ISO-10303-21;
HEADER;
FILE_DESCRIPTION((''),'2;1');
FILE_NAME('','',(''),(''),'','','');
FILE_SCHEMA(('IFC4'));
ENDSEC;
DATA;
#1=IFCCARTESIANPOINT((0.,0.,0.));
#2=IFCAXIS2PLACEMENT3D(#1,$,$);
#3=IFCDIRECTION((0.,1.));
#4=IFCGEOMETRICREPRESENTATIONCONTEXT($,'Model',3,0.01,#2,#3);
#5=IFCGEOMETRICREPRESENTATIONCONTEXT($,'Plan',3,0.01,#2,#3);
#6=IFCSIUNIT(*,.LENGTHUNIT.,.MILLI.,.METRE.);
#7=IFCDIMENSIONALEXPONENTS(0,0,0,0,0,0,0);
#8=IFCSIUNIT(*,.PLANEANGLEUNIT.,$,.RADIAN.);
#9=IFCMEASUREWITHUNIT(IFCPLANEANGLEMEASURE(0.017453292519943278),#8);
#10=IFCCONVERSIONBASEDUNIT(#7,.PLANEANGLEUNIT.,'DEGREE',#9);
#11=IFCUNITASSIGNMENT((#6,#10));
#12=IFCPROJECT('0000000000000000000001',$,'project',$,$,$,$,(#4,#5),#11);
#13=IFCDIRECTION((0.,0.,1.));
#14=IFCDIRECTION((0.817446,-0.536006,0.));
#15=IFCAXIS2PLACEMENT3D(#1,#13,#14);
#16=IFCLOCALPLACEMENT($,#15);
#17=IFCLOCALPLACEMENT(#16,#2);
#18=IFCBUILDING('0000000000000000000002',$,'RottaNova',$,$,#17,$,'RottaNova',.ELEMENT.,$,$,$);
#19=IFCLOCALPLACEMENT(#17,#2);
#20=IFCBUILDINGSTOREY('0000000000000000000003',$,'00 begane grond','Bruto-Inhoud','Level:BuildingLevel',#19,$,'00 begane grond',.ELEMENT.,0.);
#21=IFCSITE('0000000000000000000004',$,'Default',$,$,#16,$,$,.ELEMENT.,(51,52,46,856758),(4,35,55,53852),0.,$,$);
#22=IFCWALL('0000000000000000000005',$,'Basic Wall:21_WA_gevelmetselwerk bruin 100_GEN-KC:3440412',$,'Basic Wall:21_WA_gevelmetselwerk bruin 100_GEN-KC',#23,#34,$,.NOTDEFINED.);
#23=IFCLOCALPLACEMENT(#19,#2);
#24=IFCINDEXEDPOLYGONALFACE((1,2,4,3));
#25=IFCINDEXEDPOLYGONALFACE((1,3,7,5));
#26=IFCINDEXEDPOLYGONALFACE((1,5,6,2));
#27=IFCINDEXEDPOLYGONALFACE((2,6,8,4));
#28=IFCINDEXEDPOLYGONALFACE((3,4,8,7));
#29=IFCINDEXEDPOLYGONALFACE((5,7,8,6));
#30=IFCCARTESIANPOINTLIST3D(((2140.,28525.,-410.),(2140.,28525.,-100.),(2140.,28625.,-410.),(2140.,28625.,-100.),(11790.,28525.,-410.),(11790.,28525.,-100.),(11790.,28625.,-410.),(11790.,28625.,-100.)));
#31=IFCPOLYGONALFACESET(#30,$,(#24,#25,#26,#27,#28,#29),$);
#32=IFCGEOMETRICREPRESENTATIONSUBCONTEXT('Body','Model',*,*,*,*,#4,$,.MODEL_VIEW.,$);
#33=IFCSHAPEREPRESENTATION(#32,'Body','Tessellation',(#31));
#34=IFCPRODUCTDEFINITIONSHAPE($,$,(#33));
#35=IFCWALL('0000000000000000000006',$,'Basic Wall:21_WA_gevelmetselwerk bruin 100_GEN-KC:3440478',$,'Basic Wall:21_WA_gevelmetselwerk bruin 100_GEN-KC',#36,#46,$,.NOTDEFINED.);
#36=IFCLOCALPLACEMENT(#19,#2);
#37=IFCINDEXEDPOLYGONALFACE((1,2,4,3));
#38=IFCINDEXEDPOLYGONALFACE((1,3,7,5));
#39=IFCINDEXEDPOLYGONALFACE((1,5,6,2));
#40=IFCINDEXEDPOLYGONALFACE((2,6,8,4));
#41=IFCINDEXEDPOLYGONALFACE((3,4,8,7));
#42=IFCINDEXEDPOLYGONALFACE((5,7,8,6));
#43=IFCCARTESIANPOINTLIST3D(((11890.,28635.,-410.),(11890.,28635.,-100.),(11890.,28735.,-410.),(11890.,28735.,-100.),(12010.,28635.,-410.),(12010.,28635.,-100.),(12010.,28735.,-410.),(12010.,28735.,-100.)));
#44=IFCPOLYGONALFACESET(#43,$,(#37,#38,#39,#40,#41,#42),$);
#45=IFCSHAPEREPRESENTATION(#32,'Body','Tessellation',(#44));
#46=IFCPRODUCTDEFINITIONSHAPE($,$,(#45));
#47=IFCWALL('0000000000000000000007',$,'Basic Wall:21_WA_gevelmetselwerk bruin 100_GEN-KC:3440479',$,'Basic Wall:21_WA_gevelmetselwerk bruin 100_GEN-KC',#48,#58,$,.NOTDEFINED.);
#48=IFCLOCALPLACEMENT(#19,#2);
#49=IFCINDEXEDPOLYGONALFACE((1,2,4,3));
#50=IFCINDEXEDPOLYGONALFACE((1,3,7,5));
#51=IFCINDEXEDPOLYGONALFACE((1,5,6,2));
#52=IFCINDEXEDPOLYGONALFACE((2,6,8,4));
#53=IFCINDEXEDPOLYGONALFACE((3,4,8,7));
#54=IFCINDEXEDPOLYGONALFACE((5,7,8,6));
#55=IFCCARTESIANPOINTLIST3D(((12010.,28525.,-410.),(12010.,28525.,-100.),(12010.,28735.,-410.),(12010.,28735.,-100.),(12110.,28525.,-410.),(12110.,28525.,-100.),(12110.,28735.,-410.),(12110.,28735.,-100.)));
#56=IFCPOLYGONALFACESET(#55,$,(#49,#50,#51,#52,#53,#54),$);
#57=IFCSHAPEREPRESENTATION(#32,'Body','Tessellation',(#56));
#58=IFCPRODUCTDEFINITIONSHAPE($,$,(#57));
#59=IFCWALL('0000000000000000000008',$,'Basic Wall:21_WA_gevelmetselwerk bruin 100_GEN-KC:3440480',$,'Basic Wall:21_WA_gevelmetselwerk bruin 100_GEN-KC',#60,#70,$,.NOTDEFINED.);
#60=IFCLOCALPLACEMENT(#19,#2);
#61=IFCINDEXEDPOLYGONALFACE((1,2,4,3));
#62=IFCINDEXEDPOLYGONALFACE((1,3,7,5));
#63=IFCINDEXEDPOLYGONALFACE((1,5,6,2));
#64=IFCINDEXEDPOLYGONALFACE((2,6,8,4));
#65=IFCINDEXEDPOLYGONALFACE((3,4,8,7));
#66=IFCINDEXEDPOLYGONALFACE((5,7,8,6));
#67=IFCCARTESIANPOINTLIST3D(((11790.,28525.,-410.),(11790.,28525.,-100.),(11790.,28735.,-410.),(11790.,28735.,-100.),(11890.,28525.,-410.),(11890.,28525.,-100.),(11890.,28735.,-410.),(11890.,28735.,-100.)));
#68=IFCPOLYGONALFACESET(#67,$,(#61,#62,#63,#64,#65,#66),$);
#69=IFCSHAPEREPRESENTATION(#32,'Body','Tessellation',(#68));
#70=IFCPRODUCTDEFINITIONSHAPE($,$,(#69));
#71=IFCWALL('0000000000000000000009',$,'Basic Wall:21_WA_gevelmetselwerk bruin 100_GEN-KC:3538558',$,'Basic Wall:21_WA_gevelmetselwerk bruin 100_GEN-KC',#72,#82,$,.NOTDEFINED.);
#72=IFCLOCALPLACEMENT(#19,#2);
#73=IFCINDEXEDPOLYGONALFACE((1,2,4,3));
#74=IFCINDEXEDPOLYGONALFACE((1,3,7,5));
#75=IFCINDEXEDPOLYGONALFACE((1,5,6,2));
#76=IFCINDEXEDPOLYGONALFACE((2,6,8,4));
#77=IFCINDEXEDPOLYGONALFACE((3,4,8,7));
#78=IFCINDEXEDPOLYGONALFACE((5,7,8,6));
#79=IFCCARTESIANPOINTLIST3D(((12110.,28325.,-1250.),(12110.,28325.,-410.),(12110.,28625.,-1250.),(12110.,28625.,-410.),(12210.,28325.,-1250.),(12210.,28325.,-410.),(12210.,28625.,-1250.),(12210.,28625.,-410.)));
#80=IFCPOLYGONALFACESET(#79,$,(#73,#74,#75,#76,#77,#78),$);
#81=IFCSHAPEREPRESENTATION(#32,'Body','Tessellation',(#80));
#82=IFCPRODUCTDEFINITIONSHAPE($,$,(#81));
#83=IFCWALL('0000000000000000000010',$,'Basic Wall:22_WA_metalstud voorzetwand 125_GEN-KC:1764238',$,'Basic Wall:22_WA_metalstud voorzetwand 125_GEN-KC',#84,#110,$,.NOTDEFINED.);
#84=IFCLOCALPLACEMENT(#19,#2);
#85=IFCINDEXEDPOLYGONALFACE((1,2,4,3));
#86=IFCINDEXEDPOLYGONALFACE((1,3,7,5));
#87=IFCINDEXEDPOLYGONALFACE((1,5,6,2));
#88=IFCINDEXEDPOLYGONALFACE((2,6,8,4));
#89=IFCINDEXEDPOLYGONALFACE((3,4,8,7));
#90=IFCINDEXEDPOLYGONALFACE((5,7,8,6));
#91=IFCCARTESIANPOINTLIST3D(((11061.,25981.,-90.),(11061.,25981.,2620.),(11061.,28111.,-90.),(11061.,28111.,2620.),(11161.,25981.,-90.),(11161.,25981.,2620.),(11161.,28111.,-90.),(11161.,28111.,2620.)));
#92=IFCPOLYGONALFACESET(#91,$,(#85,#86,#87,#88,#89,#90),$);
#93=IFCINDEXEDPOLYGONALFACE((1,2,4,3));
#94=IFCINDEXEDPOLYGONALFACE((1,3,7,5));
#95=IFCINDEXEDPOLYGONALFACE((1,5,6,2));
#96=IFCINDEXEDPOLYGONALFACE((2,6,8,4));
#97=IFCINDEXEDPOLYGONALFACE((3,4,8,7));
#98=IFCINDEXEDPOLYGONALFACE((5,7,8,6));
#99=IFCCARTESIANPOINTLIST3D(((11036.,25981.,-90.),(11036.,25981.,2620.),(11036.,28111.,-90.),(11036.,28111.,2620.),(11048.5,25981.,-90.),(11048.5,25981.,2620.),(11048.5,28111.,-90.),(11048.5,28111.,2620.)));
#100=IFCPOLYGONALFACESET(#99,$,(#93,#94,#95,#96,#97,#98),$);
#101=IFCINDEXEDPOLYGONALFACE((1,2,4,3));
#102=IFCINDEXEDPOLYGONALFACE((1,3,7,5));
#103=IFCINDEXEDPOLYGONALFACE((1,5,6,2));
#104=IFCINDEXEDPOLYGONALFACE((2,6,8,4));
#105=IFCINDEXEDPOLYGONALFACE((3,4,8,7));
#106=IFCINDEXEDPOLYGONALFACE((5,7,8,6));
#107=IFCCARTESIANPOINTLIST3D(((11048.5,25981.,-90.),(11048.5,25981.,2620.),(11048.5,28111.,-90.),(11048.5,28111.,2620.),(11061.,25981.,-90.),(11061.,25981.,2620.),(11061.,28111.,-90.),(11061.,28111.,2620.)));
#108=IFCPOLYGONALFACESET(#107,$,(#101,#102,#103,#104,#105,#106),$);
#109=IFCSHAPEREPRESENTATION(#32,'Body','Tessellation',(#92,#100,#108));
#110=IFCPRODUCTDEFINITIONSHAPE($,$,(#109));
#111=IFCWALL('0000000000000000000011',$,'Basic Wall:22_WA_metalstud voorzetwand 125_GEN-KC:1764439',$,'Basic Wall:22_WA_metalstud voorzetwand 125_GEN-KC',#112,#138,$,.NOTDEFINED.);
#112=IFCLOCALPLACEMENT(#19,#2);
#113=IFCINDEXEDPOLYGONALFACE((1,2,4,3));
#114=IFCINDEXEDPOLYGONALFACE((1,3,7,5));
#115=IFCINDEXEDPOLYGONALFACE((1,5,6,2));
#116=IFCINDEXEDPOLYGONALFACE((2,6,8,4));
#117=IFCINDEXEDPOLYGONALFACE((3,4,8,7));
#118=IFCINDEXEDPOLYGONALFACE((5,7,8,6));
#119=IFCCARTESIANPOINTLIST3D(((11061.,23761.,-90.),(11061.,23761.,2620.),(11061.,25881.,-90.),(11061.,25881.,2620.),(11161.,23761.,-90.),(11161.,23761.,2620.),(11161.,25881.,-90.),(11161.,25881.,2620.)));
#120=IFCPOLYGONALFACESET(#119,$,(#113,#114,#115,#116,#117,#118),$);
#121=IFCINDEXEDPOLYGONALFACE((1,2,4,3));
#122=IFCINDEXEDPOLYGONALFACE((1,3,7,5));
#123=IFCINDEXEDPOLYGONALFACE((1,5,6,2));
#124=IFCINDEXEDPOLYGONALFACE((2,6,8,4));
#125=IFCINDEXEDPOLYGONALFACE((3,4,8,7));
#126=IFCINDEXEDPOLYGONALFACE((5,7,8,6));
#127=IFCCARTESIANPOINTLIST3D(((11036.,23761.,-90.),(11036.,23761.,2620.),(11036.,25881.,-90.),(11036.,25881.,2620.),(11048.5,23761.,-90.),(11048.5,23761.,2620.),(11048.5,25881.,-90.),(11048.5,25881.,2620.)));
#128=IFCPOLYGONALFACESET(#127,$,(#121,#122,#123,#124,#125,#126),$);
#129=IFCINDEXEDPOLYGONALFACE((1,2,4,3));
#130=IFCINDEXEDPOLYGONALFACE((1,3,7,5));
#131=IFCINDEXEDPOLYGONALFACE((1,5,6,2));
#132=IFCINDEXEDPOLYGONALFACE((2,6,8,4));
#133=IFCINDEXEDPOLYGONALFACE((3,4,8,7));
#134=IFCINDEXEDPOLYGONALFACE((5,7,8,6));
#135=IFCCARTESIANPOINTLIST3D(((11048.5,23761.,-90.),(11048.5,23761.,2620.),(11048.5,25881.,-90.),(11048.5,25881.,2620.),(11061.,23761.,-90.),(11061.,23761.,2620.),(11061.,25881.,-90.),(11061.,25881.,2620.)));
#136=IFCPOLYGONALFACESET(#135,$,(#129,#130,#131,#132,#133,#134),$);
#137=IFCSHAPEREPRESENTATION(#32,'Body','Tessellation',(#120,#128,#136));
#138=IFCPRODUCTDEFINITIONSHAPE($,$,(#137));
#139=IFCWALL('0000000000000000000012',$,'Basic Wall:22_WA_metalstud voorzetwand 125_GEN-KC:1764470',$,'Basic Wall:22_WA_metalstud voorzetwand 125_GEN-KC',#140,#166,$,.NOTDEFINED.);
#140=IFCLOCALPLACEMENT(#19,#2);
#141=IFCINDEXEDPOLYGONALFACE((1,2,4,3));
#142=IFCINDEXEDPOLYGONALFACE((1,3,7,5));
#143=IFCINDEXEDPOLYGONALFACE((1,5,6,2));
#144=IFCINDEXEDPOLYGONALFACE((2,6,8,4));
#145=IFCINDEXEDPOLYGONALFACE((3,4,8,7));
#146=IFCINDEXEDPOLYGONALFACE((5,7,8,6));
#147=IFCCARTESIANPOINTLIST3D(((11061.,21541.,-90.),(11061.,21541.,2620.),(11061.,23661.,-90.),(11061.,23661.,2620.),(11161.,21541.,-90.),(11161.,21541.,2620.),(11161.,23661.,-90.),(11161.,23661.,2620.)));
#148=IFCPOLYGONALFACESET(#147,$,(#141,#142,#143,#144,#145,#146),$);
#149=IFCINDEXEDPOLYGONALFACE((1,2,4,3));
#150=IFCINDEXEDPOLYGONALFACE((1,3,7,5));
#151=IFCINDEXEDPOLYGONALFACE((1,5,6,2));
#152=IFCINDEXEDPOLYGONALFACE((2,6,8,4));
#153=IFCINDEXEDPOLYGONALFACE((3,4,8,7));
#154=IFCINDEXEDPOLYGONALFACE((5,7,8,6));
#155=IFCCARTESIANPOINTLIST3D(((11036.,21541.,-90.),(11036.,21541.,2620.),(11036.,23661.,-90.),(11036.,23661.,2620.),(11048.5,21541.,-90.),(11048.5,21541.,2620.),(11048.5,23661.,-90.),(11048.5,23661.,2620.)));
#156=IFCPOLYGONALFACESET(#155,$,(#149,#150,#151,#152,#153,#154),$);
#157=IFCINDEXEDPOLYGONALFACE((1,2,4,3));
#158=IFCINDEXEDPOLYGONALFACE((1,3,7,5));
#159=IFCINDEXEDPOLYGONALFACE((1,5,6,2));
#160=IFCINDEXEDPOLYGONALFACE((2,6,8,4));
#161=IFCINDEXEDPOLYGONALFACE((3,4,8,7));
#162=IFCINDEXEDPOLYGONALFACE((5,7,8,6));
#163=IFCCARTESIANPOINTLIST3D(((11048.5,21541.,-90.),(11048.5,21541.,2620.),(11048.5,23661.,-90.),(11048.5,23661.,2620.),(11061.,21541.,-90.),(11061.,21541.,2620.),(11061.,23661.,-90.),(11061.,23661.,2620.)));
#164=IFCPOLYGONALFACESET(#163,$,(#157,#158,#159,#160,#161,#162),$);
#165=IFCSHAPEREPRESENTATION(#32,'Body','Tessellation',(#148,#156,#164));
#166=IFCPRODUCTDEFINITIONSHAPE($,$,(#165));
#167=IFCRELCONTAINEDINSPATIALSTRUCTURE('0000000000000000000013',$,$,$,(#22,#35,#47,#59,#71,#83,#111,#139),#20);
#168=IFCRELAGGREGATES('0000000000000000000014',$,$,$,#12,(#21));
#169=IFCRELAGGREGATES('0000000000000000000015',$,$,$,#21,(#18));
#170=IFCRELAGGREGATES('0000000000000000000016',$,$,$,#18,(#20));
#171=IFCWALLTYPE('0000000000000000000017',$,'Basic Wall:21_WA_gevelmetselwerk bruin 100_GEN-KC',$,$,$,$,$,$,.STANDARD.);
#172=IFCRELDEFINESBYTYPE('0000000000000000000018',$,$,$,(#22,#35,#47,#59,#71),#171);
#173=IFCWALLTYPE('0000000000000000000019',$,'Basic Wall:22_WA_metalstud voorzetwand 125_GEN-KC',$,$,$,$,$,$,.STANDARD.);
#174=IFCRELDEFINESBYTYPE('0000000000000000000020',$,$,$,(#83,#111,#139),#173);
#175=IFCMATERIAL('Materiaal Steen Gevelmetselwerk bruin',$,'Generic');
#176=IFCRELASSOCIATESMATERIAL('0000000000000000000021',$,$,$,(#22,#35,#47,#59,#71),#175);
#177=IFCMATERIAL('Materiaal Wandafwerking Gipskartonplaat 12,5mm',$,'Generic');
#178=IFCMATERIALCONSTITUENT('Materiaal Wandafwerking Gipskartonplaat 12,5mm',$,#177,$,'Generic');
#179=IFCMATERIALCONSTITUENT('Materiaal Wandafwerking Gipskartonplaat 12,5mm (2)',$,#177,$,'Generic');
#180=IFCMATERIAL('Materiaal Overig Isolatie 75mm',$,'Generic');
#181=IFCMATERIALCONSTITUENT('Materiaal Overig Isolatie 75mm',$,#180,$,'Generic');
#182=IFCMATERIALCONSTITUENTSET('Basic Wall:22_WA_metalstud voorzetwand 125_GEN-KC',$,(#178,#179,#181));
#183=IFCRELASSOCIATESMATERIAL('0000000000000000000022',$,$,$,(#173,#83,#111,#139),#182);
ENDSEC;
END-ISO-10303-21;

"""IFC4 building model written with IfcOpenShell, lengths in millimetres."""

from ifc_helpers import new_model, entity, si_unit, converted_unit, direction, frame, origin, place, context, subcontext, project, spatial, indexed_curve, outline, extrude, material, constituent, constituent_set, type_object, element, save


model = new_model("IFC4")

# Units and contexts
model_context = context("Model", 3, precision=0.01, world=origin(), true_north=direction((0.0, 1.0)))
plan_context = context("Plan", 3, precision=0.01, world=origin(), true_north=direction((0.0, 1.0)))
body_context = subcontext(model_context, "Body", "Model", "MODEL_VIEW")
ifc_project = project(units=[si_unit("LENGTHUNIT", "METRE", prefix="MILLI"), converted_unit("PLANEANGLEUNIT", "DEGREE", entity("IfcPlaneAngleMeasure", 0.017453292519943278), si_unit("PLANEANGLEUNIT", "RADIAN"), dimensions=[0, 0, 0, 0, 0, 0, 0])], contexts=[model_context, plan_context])

# Site, building, storey
site_placement = place(None, frame((0.0, 0.0, 0.0), z_axis=(0.0, 0.0, 1.0), x_axis=(0.817446, -0.536006, 0.0)))
site = spatial("IfcSite", under=ifc_project, at=site_placement, Name="Default", CompositionType="ELEMENT", RefLatitude=(51, 52, 46, 856758), RefLongitude=(4, 35, 55, 53852), RefElevation=0.0)
building_placement = place(site_placement, origin())
building = spatial("IfcBuilding", under=site, at=building_placement, Name="RottaNova", LongName="RottaNova", CompositionType="ELEMENT")
storey_placement = place(building_placement, origin())
storey = spatial("IfcBuildingStorey", under=building, at=storey_placement, Name="00 begane grond", Description="Bruto-Inhoud", ObjectType="Level:BuildingLevel", LongName="00 begane grond", CompositionType="ELEMENT", Elevation=0.0)

# Walls
ifc_material_1 = material(Name="Materiaal Steen Gevelmetselwerk bruin", Category="Generic")
wall_type_1 = type_object("IfcWallType", Name="Basic Wall:21_WA_gevelmetselwerk bruin 100_GEN-KC", PredefinedType="STANDARD")
wall_1_placement = place(storey_placement, frame((11790.0, 28575.0, -410.0), z_axis=(0.0, 0.0, 1.0), x_axis=(-1.0, 0.0, 0.0)))
element("IfcWall", 1, at=wall_1_placement, inside=storey, type_object=wall_type_1, material=ifc_material_1, Name="Basic Wall:21_WA_gevelmetselwerk bruin 100_GEN-KC:3440412", ObjectType="Basic Wall:21_WA_gevelmetselwerk bruin 100_GEN-KC", PredefinedType="NOTDEFINED", context=body_context, shape_type="SweptSolid", body=[
    extrude(outline(indexed_curve([(9650.0, 50.0), (0.0, 50.0), (0.0, -50.0), (9650.0, -50.0), (9650.0, 50.0)], self_intersect=False)), origin(), (0.0, 0.0, 1.0), 310.0),
])
wall_2_placement = place(storey_placement, frame((12010.0, 28685.0, -410.0), z_axis=(0.0, 0.0, 1.0), x_axis=(-1.0, 0.0, 0.0)))
element("IfcWall", 2, at=wall_2_placement, inside=storey, type_object=wall_type_1, material=ifc_material_1, Name="Basic Wall:21_WA_gevelmetselwerk bruin 100_GEN-KC:3440478", ObjectType="Basic Wall:21_WA_gevelmetselwerk bruin 100_GEN-KC", PredefinedType="NOTDEFINED", context=body_context, shape_type="SweptSolid", body=[
    extrude(outline(indexed_curve([(120.0, 50.0), (0.0, 50.0), (0.0, -50.0), (120.0, -50.0), (120.0, 50.0)], self_intersect=False)), origin(), (0.0, 0.0, 1.0), 310.0),
])
wall_3_placement = place(storey_placement, frame((12060.0, 28735.0, -410.0), z_axis=(0.0, 0.0, 1.0), x_axis=(0.0, -1.0, 0.0)))
element("IfcWall", 3, at=wall_3_placement, inside=storey, type_object=wall_type_1, material=ifc_material_1, Name="Basic Wall:21_WA_gevelmetselwerk bruin 100_GEN-KC:3440479", ObjectType="Basic Wall:21_WA_gevelmetselwerk bruin 100_GEN-KC", PredefinedType="NOTDEFINED", context=body_context, shape_type="SweptSolid", body=[
    extrude(outline(indexed_curve([(210.0, 50.0), (0.0, 50.0), (0.0, -50.0), (210.0, -50.0), (210.0, 50.0)], self_intersect=False)), origin(), (0.0, 0.0, 1.0), 310.0),
])
wall_4_placement = place(storey_placement, frame((11840.0, 28735.0, -410.0), z_axis=(0.0, 0.0, 1.0), x_axis=(0.0, -1.0, 0.0)))
element("IfcWall", 4, at=wall_4_placement, inside=storey, type_object=wall_type_1, material=ifc_material_1, Name="Basic Wall:21_WA_gevelmetselwerk bruin 100_GEN-KC:3440480", ObjectType="Basic Wall:21_WA_gevelmetselwerk bruin 100_GEN-KC", PredefinedType="NOTDEFINED", context=body_context, shape_type="SweptSolid", body=[
    extrude(outline(indexed_curve([(210.0, 50.0), (0.0, 50.0), (0.0, -50.0), (210.0, -50.0), (210.0, 50.0)], self_intersect=False)), origin(), (0.0, 0.0, 1.0), 310.0),
])
wall_5_placement = place(storey_placement, frame((12160.0, 28325.0, -1250.0), z_axis=(0.0, 0.0, 1.0), x_axis=(0.0, 1.0, 0.0)))
element("IfcWall", 5, at=wall_5_placement, inside=storey, type_object=wall_type_1, material=ifc_material_1, Name="Basic Wall:21_WA_gevelmetselwerk bruin 100_GEN-KC:3538558", ObjectType="Basic Wall:21_WA_gevelmetselwerk bruin 100_GEN-KC", PredefinedType="NOTDEFINED", context=body_context, shape_type="SweptSolid", body=[
    extrude(outline(indexed_curve([(300.0, 50.0), (0.0, 50.0), (0.0, -50.0), (300.0, -50.0), (300.0, 50.0)], self_intersect=False)), origin(), (0.0, 0.0, 1.0), 840.0),
])
ifc_material_2 = material(Name="Materiaal Wandafwerking Gipskartonplaat 12,5mm", Category="Generic")
ifc_constituent_1 = constituent(ifc_material_2, Name="Materiaal Wandafwerking Gipskartonplaat 12,5mm", Category="Generic")
ifc_constituent_2 = constituent(ifc_material_2, Name="Materiaal Wandafwerking Gipskartonplaat 12,5mm (2)", Category="Generic")
ifc_material_3 = material(Name="Materiaal Overig Isolatie 75mm", Category="Generic")
ifc_constituent_3 = constituent(ifc_material_3, Name="Materiaal Overig Isolatie 75mm", Category="Generic")
ifc_constituent_set = constituent_set(constituents=[ifc_constituent_1, ifc_constituent_2, ifc_constituent_3], Name="Basic Wall:22_WA_metalstud voorzetwand 125_GEN-KC")
wall_type_2 = type_object("IfcWallType", Name="Basic Wall:22_WA_metalstud voorzetwand 125_GEN-KC", PredefinedType="STANDARD", material=ifc_constituent_set)
wall_6_placement = place(storey_placement, frame((11098.5, 28111.0, -90.0), z_axis=(0.0, 0.0, 1.0), x_axis=(0.0, -1.0, 0.0)))
element("IfcWall", 6, at=wall_6_placement, inside=storey, type_object=wall_type_2, material=ifc_constituent_set, Name="Basic Wall:22_WA_metalstud voorzetwand 125_GEN-KC:1764238", ObjectType="Basic Wall:22_WA_metalstud voorzetwand 125_GEN-KC", PredefinedType="NOTDEFINED", context=body_context, shape_type="SweptSolid", body=[
    extrude(outline(indexed_curve([(-50.0, -1065.0), (50.0, -1065.0), (50.0, 1065.0), (-50.0, 1065.0), (-50.0, -1065.0)], self_intersect=False)), frame((1065.0, 12.5, 0.0), z_axis=(0.0, 0.0, 1.0), x_axis=(0.0, -1.0, 0.0)), (0.0, 0.0, 1.0), 2710.0),
    extrude(outline(indexed_curve([(-6.3, -1065.0), (6.2, -1065.0), (6.3, 1065.0), (-6.2, 1065.0), (-6.3, -1065.0)], self_intersect=False)), frame((1065.0, -56.3, 0.0), z_axis=(0.0, 0.0, 1.0), x_axis=(0.0, 1.0, 0.0)), (0.0, 0.0, 1.0), 2710.0),
    extrude(outline(indexed_curve([(-1065.0, -6.2), (1065.0, -6.2), (1065.0, 6.3), (-1065.0, 6.3), (-1065.0, -6.2)], self_intersect=False)), frame((1065.0, -43.8, 0.0)), (0.0, 0.0, 1.0), 2710.0),
])
wall_7_placement = place(storey_placement, frame((11098.5, 25881.0, -90.0), z_axis=(0.0, 0.0, 1.0), x_axis=(0.0, -1.0, 0.0)))
element("IfcWall", 7, at=wall_7_placement, inside=storey, type_object=wall_type_2, material=ifc_constituent_set, Name="Basic Wall:22_WA_metalstud voorzetwand 125_GEN-KC:1764439", ObjectType="Basic Wall:22_WA_metalstud voorzetwand 125_GEN-KC", PredefinedType="NOTDEFINED", context=body_context, shape_type="SweptSolid", body=[
    extrude(outline(indexed_curve([(-50.0, -1060.0), (50.0, -1060.0), (50.0, 1060.0), (-50.0, 1060.0), (-50.0, -1060.0)], self_intersect=False)), frame((1060.0, 12.5, 0.0), z_axis=(0.0, 0.0, 1.0), x_axis=(0.0, -1.0, 0.0)), (0.0, 0.0, 1.0), 2710.0),
    extrude(outline(indexed_curve([(-6.3, -1060.0), (6.2, -1060.0), (6.3, 1060.0), (-6.2, 1060.0), (-6.3, -1060.0)], self_intersect=False)), frame((1060.0, -56.3, 0.0), z_axis=(0.0, 0.0, 1.0), x_axis=(0.0, 1.0, 0.0)), (0.0, 0.0, 1.0), 2710.0),
    extrude(outline(indexed_curve([(-1060.0, -6.2), (1060.0, -6.2), (1060.0, 6.3), (-1060.0, 6.3), (-1060.0, -6.2)], self_intersect=False)), frame((1060.0, -43.8, 0.0)), (0.0, 0.0, 1.0), 2710.0),
])
wall_8_placement = place(storey_placement, frame((11098.5, 23661.0, -90.0), z_axis=(0.0, 0.0, 1.0), x_axis=(0.0, -1.0, 0.0)))
element("IfcWall", 8, at=wall_8_placement, inside=storey, type_object=wall_type_2, material=ifc_constituent_set, Name="Basic Wall:22_WA_metalstud voorzetwand 125_GEN-KC:1764470", ObjectType="Basic Wall:22_WA_metalstud voorzetwand 125_GEN-KC", PredefinedType="NOTDEFINED", context=body_context, shape_type="SweptSolid", body=[
    extrude(outline(indexed_curve([(-50.0, -1060.0), (50.0, -1060.0), (50.0, 1060.0), (-50.0, 1060.0), (-50.0, -1060.0)], self_intersect=False)), frame((1060.0, 12.5, 0.0), z_axis=(0.0, 0.0, 1.0), x_axis=(0.0, -1.0, 0.0)), (0.0, 0.0, 1.0), 2710.0),
    extrude(outline(indexed_curve([(-6.3, -1060.0), (6.2, -1060.0), (6.3, 1060.0), (-6.2, 1060.0), (-6.3, -1060.0)], self_intersect=False)), frame((1060.0, -56.3, 0.0), z_axis=(0.0, 0.0, 1.0), x_axis=(0.0, 1.0, 0.0)), (0.0, 0.0, 1.0), 2710.0),
    extrude(outline(indexed_curve([(-1060.0, -6.2), (1060.0, -6.2), (1060.0, 6.3), (-1060.0, 6.3), (-1060.0, -6.2)], self_intersect=False)), frame((1060.0, -43.8, 0.0)), (0.0, 0.0, 1.0), 2710.0),
])

save(model, "model.ifc")
